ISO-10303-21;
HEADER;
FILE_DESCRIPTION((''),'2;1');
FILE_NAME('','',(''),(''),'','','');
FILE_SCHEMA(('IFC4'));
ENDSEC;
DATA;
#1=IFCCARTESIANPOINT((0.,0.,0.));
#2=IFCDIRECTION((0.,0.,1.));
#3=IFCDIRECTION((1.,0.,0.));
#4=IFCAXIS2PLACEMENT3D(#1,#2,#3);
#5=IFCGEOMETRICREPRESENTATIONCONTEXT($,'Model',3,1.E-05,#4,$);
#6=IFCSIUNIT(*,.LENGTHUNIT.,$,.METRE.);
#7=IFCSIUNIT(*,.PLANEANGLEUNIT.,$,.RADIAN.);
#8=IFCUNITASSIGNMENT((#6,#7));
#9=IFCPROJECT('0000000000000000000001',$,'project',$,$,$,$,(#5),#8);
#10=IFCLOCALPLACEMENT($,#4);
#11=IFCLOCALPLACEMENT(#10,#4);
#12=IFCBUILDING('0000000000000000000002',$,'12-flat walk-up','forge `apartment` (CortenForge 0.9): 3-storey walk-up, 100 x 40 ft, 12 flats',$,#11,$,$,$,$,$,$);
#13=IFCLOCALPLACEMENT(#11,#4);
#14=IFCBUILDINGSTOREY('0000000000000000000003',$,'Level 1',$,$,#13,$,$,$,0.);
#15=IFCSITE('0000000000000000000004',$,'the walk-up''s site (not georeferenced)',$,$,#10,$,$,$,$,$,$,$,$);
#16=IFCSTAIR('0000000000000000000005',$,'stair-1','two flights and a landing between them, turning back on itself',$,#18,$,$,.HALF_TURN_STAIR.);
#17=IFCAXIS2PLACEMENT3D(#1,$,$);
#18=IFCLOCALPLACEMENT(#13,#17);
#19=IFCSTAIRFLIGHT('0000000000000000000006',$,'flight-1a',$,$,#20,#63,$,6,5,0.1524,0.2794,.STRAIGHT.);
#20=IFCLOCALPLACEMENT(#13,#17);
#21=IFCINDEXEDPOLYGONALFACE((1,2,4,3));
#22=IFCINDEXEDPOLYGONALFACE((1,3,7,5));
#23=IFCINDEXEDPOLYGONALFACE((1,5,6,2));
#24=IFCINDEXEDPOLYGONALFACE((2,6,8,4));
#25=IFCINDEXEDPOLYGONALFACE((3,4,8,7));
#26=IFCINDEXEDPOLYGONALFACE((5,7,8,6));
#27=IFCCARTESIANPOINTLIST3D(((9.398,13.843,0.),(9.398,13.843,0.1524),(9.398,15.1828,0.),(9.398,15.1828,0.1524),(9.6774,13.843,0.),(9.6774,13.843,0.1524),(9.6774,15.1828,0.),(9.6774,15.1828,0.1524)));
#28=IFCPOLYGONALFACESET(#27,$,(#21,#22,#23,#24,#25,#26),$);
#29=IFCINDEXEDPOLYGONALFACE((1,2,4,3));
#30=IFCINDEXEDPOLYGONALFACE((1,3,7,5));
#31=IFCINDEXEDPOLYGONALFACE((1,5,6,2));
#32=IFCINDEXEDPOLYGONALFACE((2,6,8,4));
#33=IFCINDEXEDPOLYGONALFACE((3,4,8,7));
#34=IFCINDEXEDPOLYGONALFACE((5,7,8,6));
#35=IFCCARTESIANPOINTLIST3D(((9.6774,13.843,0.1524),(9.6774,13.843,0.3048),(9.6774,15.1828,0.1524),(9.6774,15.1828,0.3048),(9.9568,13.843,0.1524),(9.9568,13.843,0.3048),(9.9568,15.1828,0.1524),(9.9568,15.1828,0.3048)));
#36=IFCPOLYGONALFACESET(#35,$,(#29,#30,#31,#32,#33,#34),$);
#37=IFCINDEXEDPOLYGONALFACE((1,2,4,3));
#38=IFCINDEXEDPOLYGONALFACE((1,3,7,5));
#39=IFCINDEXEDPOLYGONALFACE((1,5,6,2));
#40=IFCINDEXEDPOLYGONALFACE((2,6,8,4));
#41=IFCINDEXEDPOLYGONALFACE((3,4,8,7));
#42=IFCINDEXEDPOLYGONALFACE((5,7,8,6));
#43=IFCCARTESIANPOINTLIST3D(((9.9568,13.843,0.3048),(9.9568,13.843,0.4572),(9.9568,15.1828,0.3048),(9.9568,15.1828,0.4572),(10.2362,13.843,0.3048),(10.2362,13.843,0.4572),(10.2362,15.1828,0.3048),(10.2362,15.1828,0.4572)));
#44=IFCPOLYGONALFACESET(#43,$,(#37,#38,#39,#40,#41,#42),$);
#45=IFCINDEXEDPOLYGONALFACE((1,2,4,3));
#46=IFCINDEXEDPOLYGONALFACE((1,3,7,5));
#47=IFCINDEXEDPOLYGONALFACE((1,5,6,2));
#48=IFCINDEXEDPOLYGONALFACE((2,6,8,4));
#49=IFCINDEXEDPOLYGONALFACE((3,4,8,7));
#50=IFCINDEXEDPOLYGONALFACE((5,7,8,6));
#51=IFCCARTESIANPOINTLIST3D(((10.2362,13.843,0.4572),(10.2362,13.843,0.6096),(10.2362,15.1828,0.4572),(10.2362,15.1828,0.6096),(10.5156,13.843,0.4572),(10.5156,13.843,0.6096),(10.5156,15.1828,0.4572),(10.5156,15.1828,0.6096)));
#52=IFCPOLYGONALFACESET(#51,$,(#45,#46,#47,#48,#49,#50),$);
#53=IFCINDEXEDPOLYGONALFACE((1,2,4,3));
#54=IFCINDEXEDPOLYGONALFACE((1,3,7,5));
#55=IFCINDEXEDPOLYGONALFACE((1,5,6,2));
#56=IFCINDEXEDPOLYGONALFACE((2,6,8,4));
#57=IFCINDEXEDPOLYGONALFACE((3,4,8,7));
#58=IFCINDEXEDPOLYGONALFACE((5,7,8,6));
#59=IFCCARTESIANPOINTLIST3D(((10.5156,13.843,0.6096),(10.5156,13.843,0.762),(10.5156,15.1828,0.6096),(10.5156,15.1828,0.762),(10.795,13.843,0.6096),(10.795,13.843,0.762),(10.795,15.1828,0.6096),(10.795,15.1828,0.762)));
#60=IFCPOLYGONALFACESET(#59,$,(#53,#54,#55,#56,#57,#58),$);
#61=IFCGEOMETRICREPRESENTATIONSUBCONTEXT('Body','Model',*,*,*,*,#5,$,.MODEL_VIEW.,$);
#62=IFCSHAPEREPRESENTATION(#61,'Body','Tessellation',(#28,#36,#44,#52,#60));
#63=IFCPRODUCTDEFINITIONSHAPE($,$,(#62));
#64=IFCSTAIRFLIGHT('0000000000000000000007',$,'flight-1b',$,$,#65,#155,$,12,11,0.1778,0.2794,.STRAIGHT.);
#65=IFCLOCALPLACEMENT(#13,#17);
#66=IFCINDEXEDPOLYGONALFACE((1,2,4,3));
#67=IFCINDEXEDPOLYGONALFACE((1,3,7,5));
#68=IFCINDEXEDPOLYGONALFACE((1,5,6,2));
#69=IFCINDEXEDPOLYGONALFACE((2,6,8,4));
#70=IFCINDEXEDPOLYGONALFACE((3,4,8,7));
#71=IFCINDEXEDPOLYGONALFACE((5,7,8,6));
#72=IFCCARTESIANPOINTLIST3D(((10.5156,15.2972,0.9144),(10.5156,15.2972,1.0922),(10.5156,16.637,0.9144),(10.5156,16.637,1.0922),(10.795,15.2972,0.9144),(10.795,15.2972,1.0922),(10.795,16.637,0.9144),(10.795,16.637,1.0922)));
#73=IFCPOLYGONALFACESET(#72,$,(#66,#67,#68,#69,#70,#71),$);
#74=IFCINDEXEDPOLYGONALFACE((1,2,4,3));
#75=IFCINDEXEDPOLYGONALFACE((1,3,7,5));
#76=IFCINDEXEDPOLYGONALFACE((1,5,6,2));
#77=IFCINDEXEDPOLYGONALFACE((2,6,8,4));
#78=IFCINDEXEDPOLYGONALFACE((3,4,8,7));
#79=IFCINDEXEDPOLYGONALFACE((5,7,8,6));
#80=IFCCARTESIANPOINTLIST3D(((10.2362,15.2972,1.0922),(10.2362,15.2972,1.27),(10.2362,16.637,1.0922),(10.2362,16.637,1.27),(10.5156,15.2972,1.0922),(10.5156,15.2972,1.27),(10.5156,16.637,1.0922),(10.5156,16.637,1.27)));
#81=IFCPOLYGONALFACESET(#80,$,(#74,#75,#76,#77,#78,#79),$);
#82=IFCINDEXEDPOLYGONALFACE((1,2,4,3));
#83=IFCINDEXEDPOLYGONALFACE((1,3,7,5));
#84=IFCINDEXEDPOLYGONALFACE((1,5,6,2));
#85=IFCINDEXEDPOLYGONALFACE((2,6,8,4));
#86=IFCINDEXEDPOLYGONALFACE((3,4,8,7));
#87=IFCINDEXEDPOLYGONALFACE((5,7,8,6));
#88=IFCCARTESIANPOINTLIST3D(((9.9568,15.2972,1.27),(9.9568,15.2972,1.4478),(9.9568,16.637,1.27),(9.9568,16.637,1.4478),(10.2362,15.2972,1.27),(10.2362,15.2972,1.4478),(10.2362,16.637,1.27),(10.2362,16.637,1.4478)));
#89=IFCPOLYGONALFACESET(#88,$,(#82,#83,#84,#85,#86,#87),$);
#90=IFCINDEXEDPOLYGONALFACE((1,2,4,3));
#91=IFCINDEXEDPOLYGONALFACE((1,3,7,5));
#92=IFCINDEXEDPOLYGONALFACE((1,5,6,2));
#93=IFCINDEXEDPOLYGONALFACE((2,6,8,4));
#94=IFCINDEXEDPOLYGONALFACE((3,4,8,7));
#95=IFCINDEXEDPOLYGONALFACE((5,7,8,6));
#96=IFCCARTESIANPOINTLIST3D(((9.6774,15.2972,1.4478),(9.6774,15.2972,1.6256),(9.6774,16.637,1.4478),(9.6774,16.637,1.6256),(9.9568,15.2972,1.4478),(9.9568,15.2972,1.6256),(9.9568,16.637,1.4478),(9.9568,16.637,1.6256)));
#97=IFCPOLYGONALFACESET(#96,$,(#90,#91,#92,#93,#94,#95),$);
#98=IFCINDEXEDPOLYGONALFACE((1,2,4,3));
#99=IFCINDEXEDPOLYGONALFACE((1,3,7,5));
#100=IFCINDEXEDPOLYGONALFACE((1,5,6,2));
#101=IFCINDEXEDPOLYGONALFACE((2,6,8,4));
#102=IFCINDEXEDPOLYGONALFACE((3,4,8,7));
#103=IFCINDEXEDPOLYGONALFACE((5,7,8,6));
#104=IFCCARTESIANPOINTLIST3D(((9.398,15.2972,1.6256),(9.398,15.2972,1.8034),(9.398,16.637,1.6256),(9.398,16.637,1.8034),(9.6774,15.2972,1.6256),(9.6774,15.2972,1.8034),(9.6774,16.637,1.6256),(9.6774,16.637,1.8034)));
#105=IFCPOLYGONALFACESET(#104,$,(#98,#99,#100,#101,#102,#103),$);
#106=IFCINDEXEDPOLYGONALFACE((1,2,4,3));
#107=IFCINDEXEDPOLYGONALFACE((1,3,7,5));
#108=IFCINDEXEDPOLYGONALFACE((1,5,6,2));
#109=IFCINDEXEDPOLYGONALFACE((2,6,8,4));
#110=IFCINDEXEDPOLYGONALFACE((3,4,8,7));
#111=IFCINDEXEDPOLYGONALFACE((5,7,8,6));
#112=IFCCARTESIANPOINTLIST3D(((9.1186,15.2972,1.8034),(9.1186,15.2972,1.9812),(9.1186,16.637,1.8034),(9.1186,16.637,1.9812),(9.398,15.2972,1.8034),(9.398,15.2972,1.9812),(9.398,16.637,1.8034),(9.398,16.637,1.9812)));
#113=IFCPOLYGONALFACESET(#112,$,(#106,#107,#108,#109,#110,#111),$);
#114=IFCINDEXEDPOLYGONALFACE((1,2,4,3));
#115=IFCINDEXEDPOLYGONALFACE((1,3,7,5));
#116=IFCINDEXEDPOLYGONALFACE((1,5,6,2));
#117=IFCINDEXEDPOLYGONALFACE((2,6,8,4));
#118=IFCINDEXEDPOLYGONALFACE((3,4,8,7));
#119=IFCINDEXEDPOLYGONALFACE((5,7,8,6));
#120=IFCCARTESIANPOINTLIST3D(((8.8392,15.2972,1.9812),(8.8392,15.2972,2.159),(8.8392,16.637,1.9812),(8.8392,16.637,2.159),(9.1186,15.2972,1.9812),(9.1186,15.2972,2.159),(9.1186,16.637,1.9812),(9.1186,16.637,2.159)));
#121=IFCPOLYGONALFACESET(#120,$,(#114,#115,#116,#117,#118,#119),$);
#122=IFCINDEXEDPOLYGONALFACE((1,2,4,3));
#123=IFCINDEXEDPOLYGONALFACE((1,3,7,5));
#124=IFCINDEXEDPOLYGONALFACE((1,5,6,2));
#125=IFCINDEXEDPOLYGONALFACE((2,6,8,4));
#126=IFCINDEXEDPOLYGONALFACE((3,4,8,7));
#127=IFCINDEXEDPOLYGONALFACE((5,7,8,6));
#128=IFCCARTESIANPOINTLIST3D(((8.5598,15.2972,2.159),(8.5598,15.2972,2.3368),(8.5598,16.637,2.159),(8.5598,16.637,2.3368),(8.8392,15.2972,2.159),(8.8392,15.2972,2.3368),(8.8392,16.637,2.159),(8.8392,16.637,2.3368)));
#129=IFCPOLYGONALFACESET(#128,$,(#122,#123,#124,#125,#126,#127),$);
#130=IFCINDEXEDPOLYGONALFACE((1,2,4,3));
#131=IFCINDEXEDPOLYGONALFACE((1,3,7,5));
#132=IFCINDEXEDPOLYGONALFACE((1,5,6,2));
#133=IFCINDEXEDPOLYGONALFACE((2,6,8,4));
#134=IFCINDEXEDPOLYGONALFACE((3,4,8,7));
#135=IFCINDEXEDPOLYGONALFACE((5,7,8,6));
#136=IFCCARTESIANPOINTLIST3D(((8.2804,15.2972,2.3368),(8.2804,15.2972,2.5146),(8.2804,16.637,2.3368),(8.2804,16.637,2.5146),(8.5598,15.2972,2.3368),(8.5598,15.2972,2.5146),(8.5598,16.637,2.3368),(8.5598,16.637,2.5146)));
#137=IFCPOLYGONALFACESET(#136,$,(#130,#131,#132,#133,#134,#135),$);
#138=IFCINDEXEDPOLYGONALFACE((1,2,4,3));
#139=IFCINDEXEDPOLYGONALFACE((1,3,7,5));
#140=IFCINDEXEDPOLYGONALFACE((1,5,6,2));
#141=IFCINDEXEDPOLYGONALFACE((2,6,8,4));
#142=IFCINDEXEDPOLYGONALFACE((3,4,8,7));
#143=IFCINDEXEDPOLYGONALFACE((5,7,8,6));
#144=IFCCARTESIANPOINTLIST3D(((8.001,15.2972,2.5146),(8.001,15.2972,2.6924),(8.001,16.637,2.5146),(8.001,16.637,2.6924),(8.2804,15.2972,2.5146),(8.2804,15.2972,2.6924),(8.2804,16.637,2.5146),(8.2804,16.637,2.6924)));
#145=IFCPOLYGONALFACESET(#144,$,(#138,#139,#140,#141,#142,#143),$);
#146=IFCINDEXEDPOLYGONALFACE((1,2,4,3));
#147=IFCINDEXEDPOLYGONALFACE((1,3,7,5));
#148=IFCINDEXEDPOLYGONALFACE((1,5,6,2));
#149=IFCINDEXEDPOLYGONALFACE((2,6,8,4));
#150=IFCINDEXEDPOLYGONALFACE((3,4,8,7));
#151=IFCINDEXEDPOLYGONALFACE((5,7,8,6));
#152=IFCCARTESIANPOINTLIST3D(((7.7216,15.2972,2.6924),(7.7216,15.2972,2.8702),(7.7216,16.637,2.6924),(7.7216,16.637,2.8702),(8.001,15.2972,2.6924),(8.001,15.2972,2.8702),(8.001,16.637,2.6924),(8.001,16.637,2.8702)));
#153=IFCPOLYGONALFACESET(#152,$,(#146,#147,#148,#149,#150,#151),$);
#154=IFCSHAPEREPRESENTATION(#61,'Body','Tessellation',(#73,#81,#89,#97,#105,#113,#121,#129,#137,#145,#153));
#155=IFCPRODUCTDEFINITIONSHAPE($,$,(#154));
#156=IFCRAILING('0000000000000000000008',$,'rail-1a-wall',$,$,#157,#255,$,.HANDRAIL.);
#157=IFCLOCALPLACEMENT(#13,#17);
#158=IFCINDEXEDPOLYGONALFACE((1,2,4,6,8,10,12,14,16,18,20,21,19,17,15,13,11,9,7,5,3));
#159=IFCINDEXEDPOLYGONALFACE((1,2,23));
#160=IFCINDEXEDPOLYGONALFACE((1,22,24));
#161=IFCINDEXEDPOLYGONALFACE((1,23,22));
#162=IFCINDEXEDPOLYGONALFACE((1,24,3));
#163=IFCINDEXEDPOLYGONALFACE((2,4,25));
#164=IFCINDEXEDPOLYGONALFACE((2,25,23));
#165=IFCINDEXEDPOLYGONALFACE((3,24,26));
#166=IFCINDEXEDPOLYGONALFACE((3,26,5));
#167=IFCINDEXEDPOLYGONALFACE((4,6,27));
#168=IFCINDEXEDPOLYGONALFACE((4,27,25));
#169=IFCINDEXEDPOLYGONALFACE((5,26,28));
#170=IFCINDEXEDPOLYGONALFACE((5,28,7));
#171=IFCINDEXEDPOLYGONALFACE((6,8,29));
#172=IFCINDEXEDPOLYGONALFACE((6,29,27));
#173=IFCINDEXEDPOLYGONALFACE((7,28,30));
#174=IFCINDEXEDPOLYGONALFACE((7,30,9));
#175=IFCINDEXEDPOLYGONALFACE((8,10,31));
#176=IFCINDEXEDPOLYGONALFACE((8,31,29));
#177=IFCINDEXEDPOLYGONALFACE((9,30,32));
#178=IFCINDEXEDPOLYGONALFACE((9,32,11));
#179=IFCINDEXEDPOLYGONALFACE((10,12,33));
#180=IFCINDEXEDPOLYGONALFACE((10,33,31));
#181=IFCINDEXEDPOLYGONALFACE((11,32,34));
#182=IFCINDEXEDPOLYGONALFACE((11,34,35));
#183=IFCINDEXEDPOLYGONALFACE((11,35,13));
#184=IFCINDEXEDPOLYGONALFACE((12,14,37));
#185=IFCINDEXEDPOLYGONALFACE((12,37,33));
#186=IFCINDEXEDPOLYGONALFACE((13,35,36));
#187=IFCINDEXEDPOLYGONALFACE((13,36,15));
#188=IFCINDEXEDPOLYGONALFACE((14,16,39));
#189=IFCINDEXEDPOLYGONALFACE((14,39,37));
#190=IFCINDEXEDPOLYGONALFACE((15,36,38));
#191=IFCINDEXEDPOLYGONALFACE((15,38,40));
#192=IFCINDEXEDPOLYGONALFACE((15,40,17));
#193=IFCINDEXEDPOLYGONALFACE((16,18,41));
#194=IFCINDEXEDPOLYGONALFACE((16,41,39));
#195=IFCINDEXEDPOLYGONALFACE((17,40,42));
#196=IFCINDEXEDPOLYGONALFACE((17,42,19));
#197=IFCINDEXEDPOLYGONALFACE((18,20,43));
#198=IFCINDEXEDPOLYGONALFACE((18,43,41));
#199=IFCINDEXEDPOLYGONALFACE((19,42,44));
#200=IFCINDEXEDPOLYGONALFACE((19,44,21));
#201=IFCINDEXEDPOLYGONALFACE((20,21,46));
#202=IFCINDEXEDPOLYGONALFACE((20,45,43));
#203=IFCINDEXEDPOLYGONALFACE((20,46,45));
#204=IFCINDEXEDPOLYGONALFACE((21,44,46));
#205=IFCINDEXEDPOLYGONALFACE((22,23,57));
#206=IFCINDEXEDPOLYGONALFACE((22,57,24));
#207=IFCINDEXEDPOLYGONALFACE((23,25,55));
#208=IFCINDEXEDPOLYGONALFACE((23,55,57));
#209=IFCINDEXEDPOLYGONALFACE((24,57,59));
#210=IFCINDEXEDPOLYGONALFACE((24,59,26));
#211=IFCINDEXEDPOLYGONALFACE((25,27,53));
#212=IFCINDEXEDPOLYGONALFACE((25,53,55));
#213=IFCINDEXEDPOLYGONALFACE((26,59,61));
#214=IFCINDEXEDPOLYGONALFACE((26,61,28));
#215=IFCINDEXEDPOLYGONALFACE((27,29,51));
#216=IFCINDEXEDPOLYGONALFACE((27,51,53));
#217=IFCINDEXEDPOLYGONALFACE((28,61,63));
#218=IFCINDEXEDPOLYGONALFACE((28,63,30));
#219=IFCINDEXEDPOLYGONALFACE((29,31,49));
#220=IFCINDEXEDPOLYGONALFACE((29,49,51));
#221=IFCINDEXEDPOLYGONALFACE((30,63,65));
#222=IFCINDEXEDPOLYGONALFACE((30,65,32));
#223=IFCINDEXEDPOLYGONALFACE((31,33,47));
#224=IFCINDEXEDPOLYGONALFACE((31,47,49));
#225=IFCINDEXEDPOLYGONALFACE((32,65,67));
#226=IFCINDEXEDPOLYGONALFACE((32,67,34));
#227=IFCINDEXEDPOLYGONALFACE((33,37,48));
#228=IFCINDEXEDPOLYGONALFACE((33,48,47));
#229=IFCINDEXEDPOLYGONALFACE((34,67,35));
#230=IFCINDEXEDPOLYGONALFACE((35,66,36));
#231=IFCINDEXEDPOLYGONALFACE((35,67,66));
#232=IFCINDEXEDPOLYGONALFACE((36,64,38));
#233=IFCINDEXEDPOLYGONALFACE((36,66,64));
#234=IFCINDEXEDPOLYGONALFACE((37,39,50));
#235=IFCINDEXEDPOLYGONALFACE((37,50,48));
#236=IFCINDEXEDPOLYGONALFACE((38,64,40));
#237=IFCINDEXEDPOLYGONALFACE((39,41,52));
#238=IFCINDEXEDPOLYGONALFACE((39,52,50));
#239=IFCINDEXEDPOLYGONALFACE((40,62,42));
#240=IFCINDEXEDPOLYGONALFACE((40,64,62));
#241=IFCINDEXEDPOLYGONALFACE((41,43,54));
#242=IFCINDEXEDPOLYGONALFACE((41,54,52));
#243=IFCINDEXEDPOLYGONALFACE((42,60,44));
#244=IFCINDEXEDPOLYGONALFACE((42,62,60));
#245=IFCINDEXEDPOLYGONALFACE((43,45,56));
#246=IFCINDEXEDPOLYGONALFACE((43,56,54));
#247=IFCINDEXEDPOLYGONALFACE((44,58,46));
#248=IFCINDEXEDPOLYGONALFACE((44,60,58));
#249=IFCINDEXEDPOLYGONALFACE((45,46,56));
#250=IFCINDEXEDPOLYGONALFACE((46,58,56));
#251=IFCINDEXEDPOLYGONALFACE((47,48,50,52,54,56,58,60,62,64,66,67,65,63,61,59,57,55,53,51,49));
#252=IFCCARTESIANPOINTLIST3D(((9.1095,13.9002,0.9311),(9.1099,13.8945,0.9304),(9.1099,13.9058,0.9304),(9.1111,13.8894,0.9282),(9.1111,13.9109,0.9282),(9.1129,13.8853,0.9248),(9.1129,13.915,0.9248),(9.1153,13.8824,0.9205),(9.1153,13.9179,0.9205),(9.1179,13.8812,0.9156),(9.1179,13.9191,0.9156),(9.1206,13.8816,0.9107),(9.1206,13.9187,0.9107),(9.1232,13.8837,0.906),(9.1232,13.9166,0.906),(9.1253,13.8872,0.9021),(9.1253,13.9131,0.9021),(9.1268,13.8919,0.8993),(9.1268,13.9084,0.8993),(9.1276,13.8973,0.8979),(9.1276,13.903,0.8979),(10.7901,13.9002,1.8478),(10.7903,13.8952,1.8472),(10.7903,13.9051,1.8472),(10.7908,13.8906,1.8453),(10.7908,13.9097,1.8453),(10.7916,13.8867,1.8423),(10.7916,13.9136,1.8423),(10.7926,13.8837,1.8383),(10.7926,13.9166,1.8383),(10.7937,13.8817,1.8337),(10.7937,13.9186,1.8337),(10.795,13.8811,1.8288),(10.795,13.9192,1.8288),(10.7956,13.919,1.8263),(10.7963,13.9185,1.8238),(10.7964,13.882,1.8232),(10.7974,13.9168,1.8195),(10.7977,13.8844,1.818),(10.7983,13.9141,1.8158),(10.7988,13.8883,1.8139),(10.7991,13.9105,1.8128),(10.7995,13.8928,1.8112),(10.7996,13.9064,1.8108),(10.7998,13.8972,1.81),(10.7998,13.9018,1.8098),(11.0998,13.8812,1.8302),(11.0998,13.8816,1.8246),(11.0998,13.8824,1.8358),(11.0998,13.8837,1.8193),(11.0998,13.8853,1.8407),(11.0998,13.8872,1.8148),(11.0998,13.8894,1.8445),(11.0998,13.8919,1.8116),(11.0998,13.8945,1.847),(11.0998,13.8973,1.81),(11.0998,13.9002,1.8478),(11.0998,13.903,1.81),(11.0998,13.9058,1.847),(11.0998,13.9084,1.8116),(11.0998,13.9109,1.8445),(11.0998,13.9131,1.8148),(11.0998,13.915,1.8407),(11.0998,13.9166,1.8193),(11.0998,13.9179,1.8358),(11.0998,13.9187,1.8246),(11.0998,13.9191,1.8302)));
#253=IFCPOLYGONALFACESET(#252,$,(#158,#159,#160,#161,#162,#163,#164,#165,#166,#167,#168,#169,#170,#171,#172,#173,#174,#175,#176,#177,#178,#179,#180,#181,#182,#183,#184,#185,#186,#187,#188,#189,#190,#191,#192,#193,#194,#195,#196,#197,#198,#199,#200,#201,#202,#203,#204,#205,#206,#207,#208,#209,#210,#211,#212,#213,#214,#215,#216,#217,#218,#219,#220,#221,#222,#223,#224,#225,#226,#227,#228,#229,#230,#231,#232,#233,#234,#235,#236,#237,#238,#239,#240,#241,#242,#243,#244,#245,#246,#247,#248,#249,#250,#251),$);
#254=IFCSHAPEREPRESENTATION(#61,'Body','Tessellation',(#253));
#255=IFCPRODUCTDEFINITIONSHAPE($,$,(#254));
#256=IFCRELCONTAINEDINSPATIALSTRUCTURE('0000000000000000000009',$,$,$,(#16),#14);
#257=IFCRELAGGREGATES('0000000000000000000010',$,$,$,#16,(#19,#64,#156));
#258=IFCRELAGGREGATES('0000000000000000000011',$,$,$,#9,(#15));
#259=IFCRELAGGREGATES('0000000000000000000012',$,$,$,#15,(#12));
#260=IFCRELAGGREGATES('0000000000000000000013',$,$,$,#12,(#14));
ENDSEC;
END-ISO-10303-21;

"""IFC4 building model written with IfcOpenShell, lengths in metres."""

from ifc_helpers import new_model, entity, si_unit, frame, frame_2d, origin, origin_with_axes, place, context, subcontext, project, spatial, rectangle, extrude, element, aggregate, save


model = new_model("IFC4")

# Units and contexts
model_context = context("Model", 3, precision=1e-05, world=origin_with_axes())
body_context = subcontext(model_context, "Body", "Model", "MODEL_VIEW")
ifc_project = project(units=[si_unit("LENGTHUNIT", "METRE"), si_unit("PLANEANGLEUNIT", "RADIAN")], contexts=[model_context])

# Site, building, storey
site_placement = place(None, origin_with_axes())
site = spatial("IfcSite", under=ifc_project, at=site_placement, Name="the walk-up's site (not georeferenced)")
building_placement = place(site_placement, origin_with_axes())
building = spatial("IfcBuilding", under=site, at=building_placement, Name="12-flat walk-up", Description="forge `apartment` (CortenForge 0.9): 3-storey walk-up, 100 x 40 ft, 12 flats")
storey_placement = place(building_placement, origin_with_axes())
storey = spatial("IfcBuildingStorey", under=building, at=storey_placement, Name="Level 1", Elevation=0.0)

# Stair, stair flights, railing
stair_placement = place(storey_placement, origin_with_axes())
stair = element("IfcStair", 1, at=stair_placement, inside=storey, Name="stair-1", Description="two flights and a landing between them, turning back on itself", PredefinedType="HALF_TURN_STAIR")
stair_flight_1_placement = place(stair_placement, frame((9.398, 13.843, 0.0), z_axis=(0.0, 0.0, 1.0), x_axis=(1.0, 0.0, 0.0)))
stair_flight_1 = element("IfcStairFlight", 2, at=stair_flight_1_placement, Name="flight-1a", NumberOfRisers=6, NumberOfTreads=5, PredefinedType="STRAIGHT", RiserHeight=0.1524, TreadLength=0.2794, context=body_context, shape_type="SweptSolid", body=[
    extrude(rectangle(XDim=0.2794, YDim=1.3399, at=frame_2d((0.1397, 0.6699))), origin(), (0.0, 0.0, 1.0), 0.1524),
    extrude(rectangle(XDim=0.2794, YDim=1.3399, at=frame_2d((0.1397, 0.6699))), frame((0.2794, 0.0, 0.1524)), (0.0, 0.0, 1.0), 0.1524),
    extrude(rectangle(XDim=0.2794, YDim=1.3399, at=frame_2d((0.1397, 0.6699))), frame((0.5588, 0.0, 0.3048)), (0.0, 0.0, 1.0), 0.1524),
    extrude(rectangle(XDim=0.2794, YDim=1.3399, at=frame_2d((0.1397, 0.6699))), frame((0.8382, 0.0, 0.4572)), (0.0, 0.0, 1.0), 0.1524),
    extrude(rectangle(XDim=0.2794, YDim=1.3399, at=frame_2d((0.1397, 0.6699))), frame((1.1176, 0.0, 0.6096)), (0.0, 0.0, 1.0), 0.1524),
])
stair_flight_2_placement = place(stair_placement, frame((7.7216, 15.2972, 0.9144), z_axis=(0.0, 0.0, 1.0), x_axis=(1.0, 0.0, 0.0)))
stair_flight_2 = element("IfcStairFlight", 3, at=stair_flight_2_placement, Name="flight-1b", NumberOfRisers=12, NumberOfTreads=11, PredefinedType="STRAIGHT", RiserHeight=0.1778, TreadLength=0.2794, context=body_context, shape_type="SweptSolid", body=[
    extrude(rectangle(XDim=0.2794, YDim=1.3399, at=frame_2d((0.1397, 0.6699))), frame((2.794, 0.0, 0.0)), (0.0, 0.0, 1.0), 0.1778),
    extrude(rectangle(XDim=0.2794, YDim=1.3399, at=frame_2d((0.1397, 0.6699))), frame((2.5146, 0.0, 0.1778)), (0.0, 0.0, 1.0), 0.1778),
    extrude(rectangle(XDim=0.2794, YDim=1.3399, at=frame_2d((0.1397, 0.6699))), frame((2.2352, 0.0, 0.3556)), (0.0, 0.0, 1.0), 0.1778),
    extrude(rectangle(XDim=0.2794, YDim=1.3399, at=frame_2d((0.1397, 0.6699))), frame((1.9558, 0.0, 0.5334)), (0.0, 0.0, 1.0), 0.1778),
    extrude(rectangle(XDim=0.2794, YDim=1.3399, at=frame_2d((0.1397, 0.6699))), frame((1.6764, 0.0, 0.7112)), (0.0, 0.0, 1.0), 0.1778),
    extrude(rectangle(XDim=0.2794, YDim=1.3399, at=frame_2d((0.1397, 0.6699))), frame((1.397, 0.0, 0.889)), (0.0, 0.0, 1.0), 0.1778),
    extrude(rectangle(XDim=0.2794, YDim=1.3399, at=frame_2d((0.1397, 0.6699))), frame((1.1176, 0.0, 1.0668)), (0.0, 0.0, 1.0), 0.1778),
    extrude(rectangle(XDim=0.2794, YDim=1.3399, at=frame_2d((0.1397, 0.6699))), frame((0.8382, 0.0, 1.2446)), (0.0, 0.0, 1.0), 0.1778),
    extrude(rectangle(XDim=0.2794, YDim=1.3399, at=frame_2d((0.1397, 0.6699))), frame((0.5588, 0.0, 1.4224)), (0.0, 0.0, 1.0), 0.1778),
    extrude(rectangle(XDim=0.2794, YDim=1.3399, at=frame_2d((0.1397, 0.6699))), frame((0.2794, 0.0, 1.6002)), (0.0, 0.0, 1.0), 0.1778),
    extrude(rectangle(XDim=0.2794, YDim=1.3399, at=frame_2d((0.1397, 0.6699))), frame((0.0, 0.0, 1.778)), (0.0, 0.0, 1.0), 0.1778),
])
railing_1_placement = place(stair_placement, frame((9.1186, 13.9002, 0.9144), z_axis=(0.0, 0.0, 1.0), x_axis=(1.0, 0.0, 0.0)))
railing_1 = element("IfcRailing", 4, at=railing_1_placement, Name="rail-1a-wall", PredefinedType="HANDRAIL", context=body_context, shape_type="AdvancedSweptSolid", body=[
    entity("IfcSweptDiskSolid", entity("IfcPolyline", [entity("IfcCartesianPoint", [0.0, 0.0, 0.0]), entity("IfcCartesianPoint", [1.6764, 0.0, 0.9144]), entity("IfcCartesianPoint", [1.9812, 0.0, 0.9144])]), 0.0191),
])
aggregate(stair, [stair_flight_1, stair_flight_2, railing_1])

save(model, "model.ifc")
